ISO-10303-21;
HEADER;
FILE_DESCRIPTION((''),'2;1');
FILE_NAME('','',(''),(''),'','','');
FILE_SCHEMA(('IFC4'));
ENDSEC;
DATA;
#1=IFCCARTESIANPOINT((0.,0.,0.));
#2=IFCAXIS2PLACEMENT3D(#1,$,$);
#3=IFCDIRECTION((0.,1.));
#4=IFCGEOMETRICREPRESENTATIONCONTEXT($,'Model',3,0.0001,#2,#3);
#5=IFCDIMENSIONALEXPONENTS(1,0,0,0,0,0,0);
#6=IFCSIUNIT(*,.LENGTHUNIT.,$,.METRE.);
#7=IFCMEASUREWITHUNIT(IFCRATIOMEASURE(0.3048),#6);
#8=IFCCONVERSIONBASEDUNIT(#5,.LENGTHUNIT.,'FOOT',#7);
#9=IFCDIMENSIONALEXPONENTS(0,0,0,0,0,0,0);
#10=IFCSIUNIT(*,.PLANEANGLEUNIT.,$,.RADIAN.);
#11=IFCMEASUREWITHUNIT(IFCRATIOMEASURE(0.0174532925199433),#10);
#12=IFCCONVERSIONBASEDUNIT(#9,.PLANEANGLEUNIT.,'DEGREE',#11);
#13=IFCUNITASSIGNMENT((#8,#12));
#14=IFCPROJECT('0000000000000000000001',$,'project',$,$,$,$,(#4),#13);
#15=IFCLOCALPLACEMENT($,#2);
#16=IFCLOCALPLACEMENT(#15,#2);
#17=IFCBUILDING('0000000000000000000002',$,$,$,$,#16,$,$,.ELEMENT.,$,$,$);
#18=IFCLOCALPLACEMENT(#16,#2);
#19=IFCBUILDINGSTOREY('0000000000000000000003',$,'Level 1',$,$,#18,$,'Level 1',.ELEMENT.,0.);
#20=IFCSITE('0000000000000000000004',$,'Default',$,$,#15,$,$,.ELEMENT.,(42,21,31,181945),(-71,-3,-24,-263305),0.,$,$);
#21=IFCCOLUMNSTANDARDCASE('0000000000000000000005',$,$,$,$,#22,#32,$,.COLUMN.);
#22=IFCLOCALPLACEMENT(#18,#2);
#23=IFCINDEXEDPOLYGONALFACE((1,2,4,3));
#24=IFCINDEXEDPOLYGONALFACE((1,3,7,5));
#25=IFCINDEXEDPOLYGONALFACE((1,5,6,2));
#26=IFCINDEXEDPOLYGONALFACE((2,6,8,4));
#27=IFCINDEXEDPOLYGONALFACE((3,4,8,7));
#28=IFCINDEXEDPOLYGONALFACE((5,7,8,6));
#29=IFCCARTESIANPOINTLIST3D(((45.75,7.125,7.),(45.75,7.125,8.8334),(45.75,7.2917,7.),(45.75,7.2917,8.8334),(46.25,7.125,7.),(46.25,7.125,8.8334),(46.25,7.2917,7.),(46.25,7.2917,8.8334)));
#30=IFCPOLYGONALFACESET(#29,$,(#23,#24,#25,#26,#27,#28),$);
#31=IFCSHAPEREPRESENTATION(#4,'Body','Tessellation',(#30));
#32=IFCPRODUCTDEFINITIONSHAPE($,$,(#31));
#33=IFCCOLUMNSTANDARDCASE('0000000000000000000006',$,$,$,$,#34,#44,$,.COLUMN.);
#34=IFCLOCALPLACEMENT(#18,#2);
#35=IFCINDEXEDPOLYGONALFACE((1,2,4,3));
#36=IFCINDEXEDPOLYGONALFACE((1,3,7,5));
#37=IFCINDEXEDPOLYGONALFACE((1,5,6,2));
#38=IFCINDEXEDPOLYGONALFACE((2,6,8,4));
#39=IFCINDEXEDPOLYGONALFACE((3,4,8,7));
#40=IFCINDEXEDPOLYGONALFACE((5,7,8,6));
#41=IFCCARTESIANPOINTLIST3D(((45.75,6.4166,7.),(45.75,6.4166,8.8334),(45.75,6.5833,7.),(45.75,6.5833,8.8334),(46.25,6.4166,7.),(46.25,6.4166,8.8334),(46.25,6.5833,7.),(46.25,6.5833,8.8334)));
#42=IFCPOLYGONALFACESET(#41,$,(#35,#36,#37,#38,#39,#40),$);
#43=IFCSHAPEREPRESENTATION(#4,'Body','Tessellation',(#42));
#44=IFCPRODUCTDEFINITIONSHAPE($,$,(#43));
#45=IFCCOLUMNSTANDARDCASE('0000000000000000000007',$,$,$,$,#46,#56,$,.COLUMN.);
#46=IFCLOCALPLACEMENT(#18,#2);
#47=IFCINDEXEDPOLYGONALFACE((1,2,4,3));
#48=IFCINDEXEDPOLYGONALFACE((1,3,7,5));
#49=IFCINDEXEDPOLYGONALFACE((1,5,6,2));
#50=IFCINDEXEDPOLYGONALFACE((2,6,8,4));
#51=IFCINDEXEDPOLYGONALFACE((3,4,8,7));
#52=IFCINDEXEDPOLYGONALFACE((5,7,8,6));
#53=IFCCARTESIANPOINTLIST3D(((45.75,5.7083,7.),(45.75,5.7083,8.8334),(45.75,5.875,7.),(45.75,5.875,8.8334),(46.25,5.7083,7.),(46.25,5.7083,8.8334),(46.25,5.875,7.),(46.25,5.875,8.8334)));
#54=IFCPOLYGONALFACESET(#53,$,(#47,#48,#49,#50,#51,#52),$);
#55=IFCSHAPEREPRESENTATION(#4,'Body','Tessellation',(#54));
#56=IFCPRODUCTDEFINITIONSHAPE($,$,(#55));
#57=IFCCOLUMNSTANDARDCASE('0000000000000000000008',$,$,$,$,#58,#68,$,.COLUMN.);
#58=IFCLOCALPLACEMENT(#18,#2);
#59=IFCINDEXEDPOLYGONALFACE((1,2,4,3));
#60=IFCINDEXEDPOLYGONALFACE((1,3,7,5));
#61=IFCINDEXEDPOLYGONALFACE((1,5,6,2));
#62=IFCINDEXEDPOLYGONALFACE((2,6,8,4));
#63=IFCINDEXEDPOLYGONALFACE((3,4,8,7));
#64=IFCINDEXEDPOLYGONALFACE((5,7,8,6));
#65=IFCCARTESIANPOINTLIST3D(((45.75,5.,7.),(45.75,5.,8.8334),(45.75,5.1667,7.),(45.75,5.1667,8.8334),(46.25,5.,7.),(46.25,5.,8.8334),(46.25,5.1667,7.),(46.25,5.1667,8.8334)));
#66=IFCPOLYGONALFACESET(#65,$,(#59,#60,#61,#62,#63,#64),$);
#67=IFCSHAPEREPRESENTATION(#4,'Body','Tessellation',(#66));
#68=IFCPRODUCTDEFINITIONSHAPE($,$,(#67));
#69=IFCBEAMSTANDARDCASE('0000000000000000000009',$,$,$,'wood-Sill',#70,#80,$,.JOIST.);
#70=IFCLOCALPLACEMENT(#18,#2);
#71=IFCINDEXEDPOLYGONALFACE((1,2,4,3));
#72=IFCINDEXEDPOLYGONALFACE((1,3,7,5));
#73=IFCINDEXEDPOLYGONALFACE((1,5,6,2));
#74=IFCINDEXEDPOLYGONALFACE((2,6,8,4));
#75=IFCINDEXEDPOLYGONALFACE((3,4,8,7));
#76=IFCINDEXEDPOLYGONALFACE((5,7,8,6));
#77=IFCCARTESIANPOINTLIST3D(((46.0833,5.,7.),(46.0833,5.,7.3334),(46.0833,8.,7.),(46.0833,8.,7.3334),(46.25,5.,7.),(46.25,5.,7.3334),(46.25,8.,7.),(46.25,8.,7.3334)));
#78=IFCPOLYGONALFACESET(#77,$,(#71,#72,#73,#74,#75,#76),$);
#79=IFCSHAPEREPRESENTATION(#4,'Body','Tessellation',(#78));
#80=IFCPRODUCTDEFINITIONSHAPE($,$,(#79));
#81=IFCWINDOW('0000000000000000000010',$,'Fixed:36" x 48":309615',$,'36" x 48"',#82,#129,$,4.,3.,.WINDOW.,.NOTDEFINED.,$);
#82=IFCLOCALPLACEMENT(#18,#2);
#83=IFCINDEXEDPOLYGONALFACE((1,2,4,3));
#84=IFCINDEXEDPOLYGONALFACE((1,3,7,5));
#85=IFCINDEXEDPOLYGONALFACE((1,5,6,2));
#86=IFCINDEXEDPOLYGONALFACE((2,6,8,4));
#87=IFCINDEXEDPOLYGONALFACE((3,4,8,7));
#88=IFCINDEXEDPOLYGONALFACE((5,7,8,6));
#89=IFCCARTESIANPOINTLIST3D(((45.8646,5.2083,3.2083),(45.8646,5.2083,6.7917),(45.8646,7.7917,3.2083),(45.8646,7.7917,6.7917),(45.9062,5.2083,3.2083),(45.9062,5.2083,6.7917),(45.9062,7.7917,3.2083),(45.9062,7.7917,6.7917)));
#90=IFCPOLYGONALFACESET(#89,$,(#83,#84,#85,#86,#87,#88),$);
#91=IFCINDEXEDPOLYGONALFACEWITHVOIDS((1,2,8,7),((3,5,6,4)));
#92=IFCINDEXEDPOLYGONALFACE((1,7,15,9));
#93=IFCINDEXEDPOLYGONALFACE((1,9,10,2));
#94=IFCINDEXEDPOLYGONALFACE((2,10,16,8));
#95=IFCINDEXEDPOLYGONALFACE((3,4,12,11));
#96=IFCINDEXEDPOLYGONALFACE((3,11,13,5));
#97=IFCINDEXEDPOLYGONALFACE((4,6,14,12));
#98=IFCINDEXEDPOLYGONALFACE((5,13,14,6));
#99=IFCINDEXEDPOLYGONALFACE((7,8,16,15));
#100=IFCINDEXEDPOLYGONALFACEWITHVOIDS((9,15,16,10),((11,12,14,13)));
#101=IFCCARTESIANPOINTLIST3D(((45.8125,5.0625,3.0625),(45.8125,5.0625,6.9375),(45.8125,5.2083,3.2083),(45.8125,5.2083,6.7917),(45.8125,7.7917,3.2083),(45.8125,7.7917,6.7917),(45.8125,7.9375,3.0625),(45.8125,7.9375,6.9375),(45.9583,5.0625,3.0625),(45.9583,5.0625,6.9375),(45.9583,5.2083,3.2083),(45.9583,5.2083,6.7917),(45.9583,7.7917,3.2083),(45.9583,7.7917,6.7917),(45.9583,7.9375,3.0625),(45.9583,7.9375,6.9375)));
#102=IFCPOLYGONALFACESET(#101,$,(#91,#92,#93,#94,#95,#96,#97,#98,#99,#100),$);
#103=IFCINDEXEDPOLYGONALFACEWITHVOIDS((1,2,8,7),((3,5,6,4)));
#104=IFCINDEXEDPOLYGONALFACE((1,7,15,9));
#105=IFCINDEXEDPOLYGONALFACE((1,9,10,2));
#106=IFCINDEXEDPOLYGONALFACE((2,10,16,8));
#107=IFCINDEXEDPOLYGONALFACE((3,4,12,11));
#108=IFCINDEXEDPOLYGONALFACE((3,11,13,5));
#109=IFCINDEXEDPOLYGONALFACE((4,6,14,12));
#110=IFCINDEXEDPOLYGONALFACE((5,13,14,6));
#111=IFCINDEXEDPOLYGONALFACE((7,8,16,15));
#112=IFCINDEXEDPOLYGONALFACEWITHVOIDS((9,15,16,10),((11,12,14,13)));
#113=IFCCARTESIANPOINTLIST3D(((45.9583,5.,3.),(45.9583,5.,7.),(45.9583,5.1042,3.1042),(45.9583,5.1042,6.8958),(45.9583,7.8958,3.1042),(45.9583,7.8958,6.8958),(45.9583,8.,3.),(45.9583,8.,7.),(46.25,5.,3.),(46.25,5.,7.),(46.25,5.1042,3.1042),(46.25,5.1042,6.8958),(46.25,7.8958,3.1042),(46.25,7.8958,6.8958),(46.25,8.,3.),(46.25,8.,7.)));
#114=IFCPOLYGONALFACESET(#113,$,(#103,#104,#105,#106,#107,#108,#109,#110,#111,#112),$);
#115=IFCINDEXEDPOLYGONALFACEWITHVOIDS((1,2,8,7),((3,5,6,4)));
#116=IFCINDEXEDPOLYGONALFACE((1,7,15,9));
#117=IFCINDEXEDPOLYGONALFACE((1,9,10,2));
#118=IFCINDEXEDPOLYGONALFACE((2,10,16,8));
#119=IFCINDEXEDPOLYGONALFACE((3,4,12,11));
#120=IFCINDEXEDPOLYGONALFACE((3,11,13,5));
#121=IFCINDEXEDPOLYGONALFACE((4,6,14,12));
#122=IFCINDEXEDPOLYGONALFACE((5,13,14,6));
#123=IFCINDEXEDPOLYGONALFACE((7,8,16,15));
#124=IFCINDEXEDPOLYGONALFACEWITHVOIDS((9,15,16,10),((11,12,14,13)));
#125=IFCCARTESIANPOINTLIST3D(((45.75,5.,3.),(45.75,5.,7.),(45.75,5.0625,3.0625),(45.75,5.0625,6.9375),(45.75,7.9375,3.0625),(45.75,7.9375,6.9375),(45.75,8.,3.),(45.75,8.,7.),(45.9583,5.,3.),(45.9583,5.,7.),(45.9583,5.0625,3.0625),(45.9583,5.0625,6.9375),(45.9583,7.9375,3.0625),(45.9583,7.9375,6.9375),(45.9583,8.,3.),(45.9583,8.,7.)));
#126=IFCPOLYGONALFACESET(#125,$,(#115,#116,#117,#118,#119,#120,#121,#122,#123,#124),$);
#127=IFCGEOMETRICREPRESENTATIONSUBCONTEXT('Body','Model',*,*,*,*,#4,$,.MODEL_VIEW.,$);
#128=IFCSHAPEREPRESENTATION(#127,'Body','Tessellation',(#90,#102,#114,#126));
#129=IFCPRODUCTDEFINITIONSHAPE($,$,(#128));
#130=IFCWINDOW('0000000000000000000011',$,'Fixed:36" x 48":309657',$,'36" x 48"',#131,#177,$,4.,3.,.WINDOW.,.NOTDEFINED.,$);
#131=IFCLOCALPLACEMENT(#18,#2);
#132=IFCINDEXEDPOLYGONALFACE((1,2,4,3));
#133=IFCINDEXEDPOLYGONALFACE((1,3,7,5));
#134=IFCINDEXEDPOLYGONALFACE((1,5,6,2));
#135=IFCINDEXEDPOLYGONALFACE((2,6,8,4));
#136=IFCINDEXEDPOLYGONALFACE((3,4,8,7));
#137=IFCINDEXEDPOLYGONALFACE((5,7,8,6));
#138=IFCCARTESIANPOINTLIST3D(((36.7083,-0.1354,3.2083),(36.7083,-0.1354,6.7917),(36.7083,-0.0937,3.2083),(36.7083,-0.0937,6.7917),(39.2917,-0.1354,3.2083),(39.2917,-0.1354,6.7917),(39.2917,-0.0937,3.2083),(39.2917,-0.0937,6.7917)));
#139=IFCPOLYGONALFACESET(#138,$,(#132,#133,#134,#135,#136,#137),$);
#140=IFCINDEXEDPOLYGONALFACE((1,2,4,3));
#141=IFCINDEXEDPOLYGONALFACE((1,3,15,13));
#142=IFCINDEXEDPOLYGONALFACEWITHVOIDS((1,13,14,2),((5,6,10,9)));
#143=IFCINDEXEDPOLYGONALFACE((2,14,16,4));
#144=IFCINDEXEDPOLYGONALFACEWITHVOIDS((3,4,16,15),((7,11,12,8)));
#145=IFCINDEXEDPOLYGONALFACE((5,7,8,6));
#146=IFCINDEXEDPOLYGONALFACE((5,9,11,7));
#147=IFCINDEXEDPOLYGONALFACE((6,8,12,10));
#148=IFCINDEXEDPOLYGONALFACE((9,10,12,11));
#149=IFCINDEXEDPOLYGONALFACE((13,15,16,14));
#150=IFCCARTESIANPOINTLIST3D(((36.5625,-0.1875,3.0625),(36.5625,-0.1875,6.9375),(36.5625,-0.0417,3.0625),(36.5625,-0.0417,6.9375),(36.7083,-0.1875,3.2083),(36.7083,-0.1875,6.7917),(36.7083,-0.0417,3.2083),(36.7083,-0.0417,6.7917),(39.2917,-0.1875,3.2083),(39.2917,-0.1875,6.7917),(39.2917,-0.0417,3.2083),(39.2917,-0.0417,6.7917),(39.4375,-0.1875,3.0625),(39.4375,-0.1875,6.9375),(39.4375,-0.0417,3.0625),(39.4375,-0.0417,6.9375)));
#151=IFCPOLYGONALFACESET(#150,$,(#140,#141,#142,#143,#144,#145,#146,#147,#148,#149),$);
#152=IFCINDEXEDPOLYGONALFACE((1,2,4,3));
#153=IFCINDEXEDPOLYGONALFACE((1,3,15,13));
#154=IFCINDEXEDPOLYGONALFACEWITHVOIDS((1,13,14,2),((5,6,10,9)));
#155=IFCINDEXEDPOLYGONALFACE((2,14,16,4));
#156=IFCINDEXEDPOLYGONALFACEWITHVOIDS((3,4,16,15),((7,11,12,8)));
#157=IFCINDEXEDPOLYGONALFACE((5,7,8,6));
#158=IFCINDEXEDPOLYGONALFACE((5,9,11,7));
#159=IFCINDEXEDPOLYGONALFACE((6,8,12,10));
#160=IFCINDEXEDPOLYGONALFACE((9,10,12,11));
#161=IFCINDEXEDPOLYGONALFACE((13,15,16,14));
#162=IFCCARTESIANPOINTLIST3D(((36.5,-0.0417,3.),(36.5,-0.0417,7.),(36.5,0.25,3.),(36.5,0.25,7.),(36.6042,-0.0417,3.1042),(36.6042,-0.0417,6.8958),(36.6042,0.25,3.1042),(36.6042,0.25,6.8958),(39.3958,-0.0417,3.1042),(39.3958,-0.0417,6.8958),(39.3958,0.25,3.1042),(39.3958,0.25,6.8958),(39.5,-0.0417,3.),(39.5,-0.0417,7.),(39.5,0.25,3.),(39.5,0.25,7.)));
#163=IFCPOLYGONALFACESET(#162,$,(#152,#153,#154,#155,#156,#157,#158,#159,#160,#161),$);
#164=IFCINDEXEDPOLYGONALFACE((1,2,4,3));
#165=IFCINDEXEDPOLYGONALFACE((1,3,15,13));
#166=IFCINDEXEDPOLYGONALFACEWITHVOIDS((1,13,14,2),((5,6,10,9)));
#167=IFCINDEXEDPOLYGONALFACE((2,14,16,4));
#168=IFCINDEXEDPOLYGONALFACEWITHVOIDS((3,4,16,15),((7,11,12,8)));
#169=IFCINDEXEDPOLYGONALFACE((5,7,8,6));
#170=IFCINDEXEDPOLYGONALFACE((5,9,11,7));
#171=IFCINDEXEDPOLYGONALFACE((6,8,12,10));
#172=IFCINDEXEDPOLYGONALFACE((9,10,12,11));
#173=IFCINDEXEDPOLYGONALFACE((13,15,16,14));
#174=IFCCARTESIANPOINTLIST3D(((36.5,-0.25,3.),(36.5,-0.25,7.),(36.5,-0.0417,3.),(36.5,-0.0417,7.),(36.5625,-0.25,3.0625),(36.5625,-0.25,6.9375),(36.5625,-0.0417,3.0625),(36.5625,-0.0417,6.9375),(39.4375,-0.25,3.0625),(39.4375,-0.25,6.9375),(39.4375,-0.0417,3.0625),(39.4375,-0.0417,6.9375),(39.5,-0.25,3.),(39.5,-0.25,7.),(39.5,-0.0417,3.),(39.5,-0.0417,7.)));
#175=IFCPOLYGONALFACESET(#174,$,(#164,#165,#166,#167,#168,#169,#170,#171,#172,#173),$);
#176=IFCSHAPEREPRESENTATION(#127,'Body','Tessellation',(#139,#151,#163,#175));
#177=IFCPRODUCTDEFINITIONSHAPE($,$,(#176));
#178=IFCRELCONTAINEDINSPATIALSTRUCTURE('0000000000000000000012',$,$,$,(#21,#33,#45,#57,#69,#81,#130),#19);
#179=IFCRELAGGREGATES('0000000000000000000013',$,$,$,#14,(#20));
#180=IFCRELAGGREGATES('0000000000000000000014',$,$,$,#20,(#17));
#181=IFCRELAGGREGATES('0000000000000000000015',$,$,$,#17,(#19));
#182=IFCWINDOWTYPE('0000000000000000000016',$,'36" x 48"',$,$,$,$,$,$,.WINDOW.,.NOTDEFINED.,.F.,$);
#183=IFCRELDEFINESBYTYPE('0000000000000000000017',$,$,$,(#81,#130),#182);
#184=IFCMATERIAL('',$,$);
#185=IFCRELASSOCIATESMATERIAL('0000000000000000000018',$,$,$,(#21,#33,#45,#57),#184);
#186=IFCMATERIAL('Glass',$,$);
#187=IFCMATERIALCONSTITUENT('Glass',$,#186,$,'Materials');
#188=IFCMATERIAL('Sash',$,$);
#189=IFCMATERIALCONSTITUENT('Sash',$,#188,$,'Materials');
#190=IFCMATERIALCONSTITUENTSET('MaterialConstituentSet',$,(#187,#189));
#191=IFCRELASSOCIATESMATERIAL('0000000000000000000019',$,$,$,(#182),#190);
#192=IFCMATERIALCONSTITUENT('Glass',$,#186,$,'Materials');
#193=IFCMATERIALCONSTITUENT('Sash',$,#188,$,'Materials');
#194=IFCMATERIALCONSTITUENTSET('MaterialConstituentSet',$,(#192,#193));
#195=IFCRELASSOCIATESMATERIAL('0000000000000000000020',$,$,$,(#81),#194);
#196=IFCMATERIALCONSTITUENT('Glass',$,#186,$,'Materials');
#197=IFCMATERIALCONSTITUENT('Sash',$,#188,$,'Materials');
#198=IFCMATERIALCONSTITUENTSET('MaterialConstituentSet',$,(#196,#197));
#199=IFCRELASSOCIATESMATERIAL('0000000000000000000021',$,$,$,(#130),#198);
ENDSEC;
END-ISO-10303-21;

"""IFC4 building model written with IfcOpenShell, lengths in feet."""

from ifc_helpers import new_model, entity, si_unit, converted_unit, direction, frame, frame_2d, origin, origin_with_axes, place, context, subcontext, project, spatial, polyline, rectangle, outline, extrude, source, transform, mapped, material, constituent, constituent_set, type_object, type_shapes, element, save


model = new_model("IFC4")

# Units and contexts
model_context = context("Model", 3, precision=0.0001, world=origin(), true_north=direction((0.0, 1.0)))
body_context = subcontext(model_context, "Body", "Model", "MODEL_VIEW")
ifc_project = project(units=[converted_unit("LENGTHUNIT", "FOOT", entity("IfcRatioMeasure", 0.3048), si_unit("LENGTHUNIT", "METRE"), dimensions=[1, 0, 0, 0, 0, 0, 0]), converted_unit("PLANEANGLEUNIT", "DEGREE", entity("IfcRatioMeasure", 0.0174532925199433), si_unit("PLANEANGLEUNIT", "RADIAN"), dimensions=[0, 0, 0, 0, 0, 0, 0])], contexts=[model_context])

# Site, building, storey
site_placement = place(None, origin())
site = spatial("IfcSite", under=ifc_project, at=site_placement, Name="Default", CompositionType="ELEMENT", RefLatitude=(42, 21, 31, 181945), RefLongitude=(-71, -3, -24, -263305), RefElevation=0.0)
building_placement = place(site_placement, origin())
building = spatial("IfcBuilding", under=site, at=building_placement, CompositionType="ELEMENT")
storey_placement = place(building_placement, origin())
storey = spatial("IfcBuildingStorey", under=building, at=storey_placement, Name="Level 1", LongName="Level 1", CompositionType="ELEMENT", Elevation=0.0)

# Columns
placement_1 = place(storey_placement, frame((46.0, 46.25, 0.0), z_axis=(0.0, 0.0, 1.0), x_axis=(0.0, -1.0, 0.0)))
ifc_material_1 = material(Name="")
for number, where, z_axis, x_axis in (
    (1, (39.0417, 0.0, 7.0), (0.0, 0.0, 1.0), (1.0, 0.0, 0.0)),
    (2, (39.7501, 0.0, 7.0), (0.0, 0.0, 1.0), (1.0, 0.0, 0.0)),
    (3, (40.4584, 0.0, 7.0), (0.0, 0.0, 1.0), (1.0, 0.0, 0.0)),
    (4, (41.1667, 0.0, 7.0), (0.0, 0.0, 1.0), (1.0, 0.0, 0.0)),
):
    element("IfcColumnStandardCase", number, at=place(placement_1, frame(where, z_axis=z_axis, x_axis=x_axis)), inside=storey, material=ifc_material_1, PredefinedType="COLUMN", context=model_context, shape_type="SweptSolid", body=[
        extrude(rectangle(XDim=0.1667, YDim=0.5), origin(), (0.0, 0.0, 1.0), 1.8334),
    ])

# Beam
for number, where, z_axis, x_axis in (
    (5, (38.25, 0.1667, 7.1667), (1.0, 0.0, 0.0), (0.0, 0.0, 1.0)),
):
    element("IfcBeamStandardCase", number, at=place(placement_1, frame(where, z_axis=z_axis, x_axis=x_axis)), inside=storey, ObjectType="wood-Sill", PredefinedType="JOIST", context=model_context, shape_type="SweptSolid", body=[
        extrude(rectangle(XDim=0.3333, YDim=0.1667), origin_with_axes(), (0.0, 0.0, 1.0), 3.0),
    ])

# Windows
ifc_material_2 = material(Name="Glass")
ifc_constituent_1 = constituent(ifc_material_2, Name="Glass", Category="Materials")
ifc_material_3 = material(Name="Sash")
ifc_constituent_2 = constituent(ifc_material_3, Name="Sash", Category="Materials")
ifc_constituent_set_1 = constituent_set(constituents=[ifc_constituent_1, ifc_constituent_2], Name="MaterialConstituentSet")
ifc_constituent_3 = constituent(ifc_material_2, Name="Glass", Category="Materials")
ifc_constituent_4 = constituent(ifc_material_3, Name="Sash", Category="Materials")
ifc_constituent_set_2 = constituent_set(constituents=[ifc_constituent_3, ifc_constituent_4], Name="MaterialConstituentSet")
window_type = type_object("IfcWindowType", Name="36\" x 48\"", ParameterTakesPrecedence=False, PartitioningType="NOTDEFINED", PredefinedType="WINDOW", material=ifc_constituent_set_2)
shared_shape = source(origin(), body_context, "Body", "SweptSolid", [
    extrude(rectangle(XDim=0.0417, YDim=2.5833, at=frame_2d((0.0, 0.0), x_axis=(1.0, 0.0))), frame((1.5, 0.3646, 0.2083), z_axis=(0.0, 0.0, 1.0), x_axis=(0.0, 1.0, 0.0)), (0.0, 0.0, 1.0), 3.5833),
    extrude(outline(polyline([(-1.4375, -1.9375), (1.4375, -1.9375), (1.4375, 1.9375), (-1.4375, 1.9375), (-1.4375, -1.9375)]), holes=[polyline([(-1.2917, -1.7917), (-1.2917, 1.7917), (1.2917, 1.7917), (1.2917, -1.7917), (-1.2917, -1.7917)])]), frame((1.5, 0.2917, 2.0), z_axis=(0.0, 1.0, 0.0), x_axis=(1.0, 0.0, 0.0)), (0.0, 0.0, 1.0), 0.1458),
    extrude(outline(polyline([(-1.5, -2.0), (1.5, -2.0), (1.5, 2.0), (-1.5, 2.0), (-1.5, -2.0)]), holes=[polyline([(-1.3958, -1.8958), (-1.3958, 1.8958), (1.3958, 1.8958), (1.3958, -1.8958), (-1.3958, -1.8958)])]), frame((1.5, 0.0, 2.0), z_axis=(0.0, 1.0, 0.0), x_axis=(1.0, 0.0, 0.0)), (0.0, 0.0, 1.0), 0.2917),
    extrude(outline(polyline([(-2.0, -1.5), (2.0, -1.5), (2.0, 1.5), (-2.0, 1.5), (-2.0, -1.5)]), holes=[polyline([(-1.9375, -1.4375), (-1.9375, 1.4375), (1.9375, 1.4375), (1.9375, -1.4375), (-1.9375, -1.4375)])]), frame((1.5, 0.2917, 2.0), z_axis=(0.0, 1.0, 0.0), x_axis=(0.0, 0.0, -1.0)), (0.0, 0.0, 1.0), 0.2083),
])
type_shapes(window_type, [shared_shape])
placement_2 = place(placement_1, frame((41.25, 0.25, 3.0)))
window_1_placement = place(placement_2, frame((0.0, 0.0, 0.0), z_axis=(0.0, 0.0, 1.0), x_axis=(-1.0, 0.0, 0.0)))
element("IfcWindow", 6, at=window_1_placement, inside=storey, type_object=window_type, material=ifc_constituent_set_1, Name="Fixed:36\" x 48\":309615", ObjectType="36\" x 48\"", OverallHeight=4.0, OverallWidth=3.0, PartitioningType="NOTDEFINED", PredefinedType="WINDOW", context=body_context, shape_type="MappedRepresentation", body=[
    mapped(shared_shape, transform((0.0, 0.0, 0.0), scale=1.0)),
])
ifc_constituent_5 = constituent(ifc_material_2, Name="Glass", Category="Materials")
ifc_constituent_6 = constituent(ifc_material_3, Name="Sash", Category="Materials")
ifc_constituent_set_3 = constituent_set(constituents=[ifc_constituent_5, ifc_constituent_6], Name="MaterialConstituentSet")
placement_3 = place(storey_placement, frame((46.25, 0.0, 0.0), z_axis=(0.0, 0.0, 1.0), x_axis=(-1.0, 0.0, 0.0)))
placement_4 = place(placement_3, frame((6.75, -0.25, 3.0)))
window_2_placement = place(placement_4, origin())
element("IfcWindow", 7, at=window_2_placement, inside=storey, type_object=window_type, material=ifc_constituent_set_3, Name="Fixed:36\" x 48\":309657", ObjectType="36\" x 48\"", OverallHeight=4.0, OverallWidth=3.0, PartitioningType="NOTDEFINED", PredefinedType="WINDOW", context=body_context, shape_type="MappedRepresentation", body=[
    mapped(shared_shape, transform((0.0, 0.0, 0.0), scale=1.0)),
])

save(model, "model.ifc")
